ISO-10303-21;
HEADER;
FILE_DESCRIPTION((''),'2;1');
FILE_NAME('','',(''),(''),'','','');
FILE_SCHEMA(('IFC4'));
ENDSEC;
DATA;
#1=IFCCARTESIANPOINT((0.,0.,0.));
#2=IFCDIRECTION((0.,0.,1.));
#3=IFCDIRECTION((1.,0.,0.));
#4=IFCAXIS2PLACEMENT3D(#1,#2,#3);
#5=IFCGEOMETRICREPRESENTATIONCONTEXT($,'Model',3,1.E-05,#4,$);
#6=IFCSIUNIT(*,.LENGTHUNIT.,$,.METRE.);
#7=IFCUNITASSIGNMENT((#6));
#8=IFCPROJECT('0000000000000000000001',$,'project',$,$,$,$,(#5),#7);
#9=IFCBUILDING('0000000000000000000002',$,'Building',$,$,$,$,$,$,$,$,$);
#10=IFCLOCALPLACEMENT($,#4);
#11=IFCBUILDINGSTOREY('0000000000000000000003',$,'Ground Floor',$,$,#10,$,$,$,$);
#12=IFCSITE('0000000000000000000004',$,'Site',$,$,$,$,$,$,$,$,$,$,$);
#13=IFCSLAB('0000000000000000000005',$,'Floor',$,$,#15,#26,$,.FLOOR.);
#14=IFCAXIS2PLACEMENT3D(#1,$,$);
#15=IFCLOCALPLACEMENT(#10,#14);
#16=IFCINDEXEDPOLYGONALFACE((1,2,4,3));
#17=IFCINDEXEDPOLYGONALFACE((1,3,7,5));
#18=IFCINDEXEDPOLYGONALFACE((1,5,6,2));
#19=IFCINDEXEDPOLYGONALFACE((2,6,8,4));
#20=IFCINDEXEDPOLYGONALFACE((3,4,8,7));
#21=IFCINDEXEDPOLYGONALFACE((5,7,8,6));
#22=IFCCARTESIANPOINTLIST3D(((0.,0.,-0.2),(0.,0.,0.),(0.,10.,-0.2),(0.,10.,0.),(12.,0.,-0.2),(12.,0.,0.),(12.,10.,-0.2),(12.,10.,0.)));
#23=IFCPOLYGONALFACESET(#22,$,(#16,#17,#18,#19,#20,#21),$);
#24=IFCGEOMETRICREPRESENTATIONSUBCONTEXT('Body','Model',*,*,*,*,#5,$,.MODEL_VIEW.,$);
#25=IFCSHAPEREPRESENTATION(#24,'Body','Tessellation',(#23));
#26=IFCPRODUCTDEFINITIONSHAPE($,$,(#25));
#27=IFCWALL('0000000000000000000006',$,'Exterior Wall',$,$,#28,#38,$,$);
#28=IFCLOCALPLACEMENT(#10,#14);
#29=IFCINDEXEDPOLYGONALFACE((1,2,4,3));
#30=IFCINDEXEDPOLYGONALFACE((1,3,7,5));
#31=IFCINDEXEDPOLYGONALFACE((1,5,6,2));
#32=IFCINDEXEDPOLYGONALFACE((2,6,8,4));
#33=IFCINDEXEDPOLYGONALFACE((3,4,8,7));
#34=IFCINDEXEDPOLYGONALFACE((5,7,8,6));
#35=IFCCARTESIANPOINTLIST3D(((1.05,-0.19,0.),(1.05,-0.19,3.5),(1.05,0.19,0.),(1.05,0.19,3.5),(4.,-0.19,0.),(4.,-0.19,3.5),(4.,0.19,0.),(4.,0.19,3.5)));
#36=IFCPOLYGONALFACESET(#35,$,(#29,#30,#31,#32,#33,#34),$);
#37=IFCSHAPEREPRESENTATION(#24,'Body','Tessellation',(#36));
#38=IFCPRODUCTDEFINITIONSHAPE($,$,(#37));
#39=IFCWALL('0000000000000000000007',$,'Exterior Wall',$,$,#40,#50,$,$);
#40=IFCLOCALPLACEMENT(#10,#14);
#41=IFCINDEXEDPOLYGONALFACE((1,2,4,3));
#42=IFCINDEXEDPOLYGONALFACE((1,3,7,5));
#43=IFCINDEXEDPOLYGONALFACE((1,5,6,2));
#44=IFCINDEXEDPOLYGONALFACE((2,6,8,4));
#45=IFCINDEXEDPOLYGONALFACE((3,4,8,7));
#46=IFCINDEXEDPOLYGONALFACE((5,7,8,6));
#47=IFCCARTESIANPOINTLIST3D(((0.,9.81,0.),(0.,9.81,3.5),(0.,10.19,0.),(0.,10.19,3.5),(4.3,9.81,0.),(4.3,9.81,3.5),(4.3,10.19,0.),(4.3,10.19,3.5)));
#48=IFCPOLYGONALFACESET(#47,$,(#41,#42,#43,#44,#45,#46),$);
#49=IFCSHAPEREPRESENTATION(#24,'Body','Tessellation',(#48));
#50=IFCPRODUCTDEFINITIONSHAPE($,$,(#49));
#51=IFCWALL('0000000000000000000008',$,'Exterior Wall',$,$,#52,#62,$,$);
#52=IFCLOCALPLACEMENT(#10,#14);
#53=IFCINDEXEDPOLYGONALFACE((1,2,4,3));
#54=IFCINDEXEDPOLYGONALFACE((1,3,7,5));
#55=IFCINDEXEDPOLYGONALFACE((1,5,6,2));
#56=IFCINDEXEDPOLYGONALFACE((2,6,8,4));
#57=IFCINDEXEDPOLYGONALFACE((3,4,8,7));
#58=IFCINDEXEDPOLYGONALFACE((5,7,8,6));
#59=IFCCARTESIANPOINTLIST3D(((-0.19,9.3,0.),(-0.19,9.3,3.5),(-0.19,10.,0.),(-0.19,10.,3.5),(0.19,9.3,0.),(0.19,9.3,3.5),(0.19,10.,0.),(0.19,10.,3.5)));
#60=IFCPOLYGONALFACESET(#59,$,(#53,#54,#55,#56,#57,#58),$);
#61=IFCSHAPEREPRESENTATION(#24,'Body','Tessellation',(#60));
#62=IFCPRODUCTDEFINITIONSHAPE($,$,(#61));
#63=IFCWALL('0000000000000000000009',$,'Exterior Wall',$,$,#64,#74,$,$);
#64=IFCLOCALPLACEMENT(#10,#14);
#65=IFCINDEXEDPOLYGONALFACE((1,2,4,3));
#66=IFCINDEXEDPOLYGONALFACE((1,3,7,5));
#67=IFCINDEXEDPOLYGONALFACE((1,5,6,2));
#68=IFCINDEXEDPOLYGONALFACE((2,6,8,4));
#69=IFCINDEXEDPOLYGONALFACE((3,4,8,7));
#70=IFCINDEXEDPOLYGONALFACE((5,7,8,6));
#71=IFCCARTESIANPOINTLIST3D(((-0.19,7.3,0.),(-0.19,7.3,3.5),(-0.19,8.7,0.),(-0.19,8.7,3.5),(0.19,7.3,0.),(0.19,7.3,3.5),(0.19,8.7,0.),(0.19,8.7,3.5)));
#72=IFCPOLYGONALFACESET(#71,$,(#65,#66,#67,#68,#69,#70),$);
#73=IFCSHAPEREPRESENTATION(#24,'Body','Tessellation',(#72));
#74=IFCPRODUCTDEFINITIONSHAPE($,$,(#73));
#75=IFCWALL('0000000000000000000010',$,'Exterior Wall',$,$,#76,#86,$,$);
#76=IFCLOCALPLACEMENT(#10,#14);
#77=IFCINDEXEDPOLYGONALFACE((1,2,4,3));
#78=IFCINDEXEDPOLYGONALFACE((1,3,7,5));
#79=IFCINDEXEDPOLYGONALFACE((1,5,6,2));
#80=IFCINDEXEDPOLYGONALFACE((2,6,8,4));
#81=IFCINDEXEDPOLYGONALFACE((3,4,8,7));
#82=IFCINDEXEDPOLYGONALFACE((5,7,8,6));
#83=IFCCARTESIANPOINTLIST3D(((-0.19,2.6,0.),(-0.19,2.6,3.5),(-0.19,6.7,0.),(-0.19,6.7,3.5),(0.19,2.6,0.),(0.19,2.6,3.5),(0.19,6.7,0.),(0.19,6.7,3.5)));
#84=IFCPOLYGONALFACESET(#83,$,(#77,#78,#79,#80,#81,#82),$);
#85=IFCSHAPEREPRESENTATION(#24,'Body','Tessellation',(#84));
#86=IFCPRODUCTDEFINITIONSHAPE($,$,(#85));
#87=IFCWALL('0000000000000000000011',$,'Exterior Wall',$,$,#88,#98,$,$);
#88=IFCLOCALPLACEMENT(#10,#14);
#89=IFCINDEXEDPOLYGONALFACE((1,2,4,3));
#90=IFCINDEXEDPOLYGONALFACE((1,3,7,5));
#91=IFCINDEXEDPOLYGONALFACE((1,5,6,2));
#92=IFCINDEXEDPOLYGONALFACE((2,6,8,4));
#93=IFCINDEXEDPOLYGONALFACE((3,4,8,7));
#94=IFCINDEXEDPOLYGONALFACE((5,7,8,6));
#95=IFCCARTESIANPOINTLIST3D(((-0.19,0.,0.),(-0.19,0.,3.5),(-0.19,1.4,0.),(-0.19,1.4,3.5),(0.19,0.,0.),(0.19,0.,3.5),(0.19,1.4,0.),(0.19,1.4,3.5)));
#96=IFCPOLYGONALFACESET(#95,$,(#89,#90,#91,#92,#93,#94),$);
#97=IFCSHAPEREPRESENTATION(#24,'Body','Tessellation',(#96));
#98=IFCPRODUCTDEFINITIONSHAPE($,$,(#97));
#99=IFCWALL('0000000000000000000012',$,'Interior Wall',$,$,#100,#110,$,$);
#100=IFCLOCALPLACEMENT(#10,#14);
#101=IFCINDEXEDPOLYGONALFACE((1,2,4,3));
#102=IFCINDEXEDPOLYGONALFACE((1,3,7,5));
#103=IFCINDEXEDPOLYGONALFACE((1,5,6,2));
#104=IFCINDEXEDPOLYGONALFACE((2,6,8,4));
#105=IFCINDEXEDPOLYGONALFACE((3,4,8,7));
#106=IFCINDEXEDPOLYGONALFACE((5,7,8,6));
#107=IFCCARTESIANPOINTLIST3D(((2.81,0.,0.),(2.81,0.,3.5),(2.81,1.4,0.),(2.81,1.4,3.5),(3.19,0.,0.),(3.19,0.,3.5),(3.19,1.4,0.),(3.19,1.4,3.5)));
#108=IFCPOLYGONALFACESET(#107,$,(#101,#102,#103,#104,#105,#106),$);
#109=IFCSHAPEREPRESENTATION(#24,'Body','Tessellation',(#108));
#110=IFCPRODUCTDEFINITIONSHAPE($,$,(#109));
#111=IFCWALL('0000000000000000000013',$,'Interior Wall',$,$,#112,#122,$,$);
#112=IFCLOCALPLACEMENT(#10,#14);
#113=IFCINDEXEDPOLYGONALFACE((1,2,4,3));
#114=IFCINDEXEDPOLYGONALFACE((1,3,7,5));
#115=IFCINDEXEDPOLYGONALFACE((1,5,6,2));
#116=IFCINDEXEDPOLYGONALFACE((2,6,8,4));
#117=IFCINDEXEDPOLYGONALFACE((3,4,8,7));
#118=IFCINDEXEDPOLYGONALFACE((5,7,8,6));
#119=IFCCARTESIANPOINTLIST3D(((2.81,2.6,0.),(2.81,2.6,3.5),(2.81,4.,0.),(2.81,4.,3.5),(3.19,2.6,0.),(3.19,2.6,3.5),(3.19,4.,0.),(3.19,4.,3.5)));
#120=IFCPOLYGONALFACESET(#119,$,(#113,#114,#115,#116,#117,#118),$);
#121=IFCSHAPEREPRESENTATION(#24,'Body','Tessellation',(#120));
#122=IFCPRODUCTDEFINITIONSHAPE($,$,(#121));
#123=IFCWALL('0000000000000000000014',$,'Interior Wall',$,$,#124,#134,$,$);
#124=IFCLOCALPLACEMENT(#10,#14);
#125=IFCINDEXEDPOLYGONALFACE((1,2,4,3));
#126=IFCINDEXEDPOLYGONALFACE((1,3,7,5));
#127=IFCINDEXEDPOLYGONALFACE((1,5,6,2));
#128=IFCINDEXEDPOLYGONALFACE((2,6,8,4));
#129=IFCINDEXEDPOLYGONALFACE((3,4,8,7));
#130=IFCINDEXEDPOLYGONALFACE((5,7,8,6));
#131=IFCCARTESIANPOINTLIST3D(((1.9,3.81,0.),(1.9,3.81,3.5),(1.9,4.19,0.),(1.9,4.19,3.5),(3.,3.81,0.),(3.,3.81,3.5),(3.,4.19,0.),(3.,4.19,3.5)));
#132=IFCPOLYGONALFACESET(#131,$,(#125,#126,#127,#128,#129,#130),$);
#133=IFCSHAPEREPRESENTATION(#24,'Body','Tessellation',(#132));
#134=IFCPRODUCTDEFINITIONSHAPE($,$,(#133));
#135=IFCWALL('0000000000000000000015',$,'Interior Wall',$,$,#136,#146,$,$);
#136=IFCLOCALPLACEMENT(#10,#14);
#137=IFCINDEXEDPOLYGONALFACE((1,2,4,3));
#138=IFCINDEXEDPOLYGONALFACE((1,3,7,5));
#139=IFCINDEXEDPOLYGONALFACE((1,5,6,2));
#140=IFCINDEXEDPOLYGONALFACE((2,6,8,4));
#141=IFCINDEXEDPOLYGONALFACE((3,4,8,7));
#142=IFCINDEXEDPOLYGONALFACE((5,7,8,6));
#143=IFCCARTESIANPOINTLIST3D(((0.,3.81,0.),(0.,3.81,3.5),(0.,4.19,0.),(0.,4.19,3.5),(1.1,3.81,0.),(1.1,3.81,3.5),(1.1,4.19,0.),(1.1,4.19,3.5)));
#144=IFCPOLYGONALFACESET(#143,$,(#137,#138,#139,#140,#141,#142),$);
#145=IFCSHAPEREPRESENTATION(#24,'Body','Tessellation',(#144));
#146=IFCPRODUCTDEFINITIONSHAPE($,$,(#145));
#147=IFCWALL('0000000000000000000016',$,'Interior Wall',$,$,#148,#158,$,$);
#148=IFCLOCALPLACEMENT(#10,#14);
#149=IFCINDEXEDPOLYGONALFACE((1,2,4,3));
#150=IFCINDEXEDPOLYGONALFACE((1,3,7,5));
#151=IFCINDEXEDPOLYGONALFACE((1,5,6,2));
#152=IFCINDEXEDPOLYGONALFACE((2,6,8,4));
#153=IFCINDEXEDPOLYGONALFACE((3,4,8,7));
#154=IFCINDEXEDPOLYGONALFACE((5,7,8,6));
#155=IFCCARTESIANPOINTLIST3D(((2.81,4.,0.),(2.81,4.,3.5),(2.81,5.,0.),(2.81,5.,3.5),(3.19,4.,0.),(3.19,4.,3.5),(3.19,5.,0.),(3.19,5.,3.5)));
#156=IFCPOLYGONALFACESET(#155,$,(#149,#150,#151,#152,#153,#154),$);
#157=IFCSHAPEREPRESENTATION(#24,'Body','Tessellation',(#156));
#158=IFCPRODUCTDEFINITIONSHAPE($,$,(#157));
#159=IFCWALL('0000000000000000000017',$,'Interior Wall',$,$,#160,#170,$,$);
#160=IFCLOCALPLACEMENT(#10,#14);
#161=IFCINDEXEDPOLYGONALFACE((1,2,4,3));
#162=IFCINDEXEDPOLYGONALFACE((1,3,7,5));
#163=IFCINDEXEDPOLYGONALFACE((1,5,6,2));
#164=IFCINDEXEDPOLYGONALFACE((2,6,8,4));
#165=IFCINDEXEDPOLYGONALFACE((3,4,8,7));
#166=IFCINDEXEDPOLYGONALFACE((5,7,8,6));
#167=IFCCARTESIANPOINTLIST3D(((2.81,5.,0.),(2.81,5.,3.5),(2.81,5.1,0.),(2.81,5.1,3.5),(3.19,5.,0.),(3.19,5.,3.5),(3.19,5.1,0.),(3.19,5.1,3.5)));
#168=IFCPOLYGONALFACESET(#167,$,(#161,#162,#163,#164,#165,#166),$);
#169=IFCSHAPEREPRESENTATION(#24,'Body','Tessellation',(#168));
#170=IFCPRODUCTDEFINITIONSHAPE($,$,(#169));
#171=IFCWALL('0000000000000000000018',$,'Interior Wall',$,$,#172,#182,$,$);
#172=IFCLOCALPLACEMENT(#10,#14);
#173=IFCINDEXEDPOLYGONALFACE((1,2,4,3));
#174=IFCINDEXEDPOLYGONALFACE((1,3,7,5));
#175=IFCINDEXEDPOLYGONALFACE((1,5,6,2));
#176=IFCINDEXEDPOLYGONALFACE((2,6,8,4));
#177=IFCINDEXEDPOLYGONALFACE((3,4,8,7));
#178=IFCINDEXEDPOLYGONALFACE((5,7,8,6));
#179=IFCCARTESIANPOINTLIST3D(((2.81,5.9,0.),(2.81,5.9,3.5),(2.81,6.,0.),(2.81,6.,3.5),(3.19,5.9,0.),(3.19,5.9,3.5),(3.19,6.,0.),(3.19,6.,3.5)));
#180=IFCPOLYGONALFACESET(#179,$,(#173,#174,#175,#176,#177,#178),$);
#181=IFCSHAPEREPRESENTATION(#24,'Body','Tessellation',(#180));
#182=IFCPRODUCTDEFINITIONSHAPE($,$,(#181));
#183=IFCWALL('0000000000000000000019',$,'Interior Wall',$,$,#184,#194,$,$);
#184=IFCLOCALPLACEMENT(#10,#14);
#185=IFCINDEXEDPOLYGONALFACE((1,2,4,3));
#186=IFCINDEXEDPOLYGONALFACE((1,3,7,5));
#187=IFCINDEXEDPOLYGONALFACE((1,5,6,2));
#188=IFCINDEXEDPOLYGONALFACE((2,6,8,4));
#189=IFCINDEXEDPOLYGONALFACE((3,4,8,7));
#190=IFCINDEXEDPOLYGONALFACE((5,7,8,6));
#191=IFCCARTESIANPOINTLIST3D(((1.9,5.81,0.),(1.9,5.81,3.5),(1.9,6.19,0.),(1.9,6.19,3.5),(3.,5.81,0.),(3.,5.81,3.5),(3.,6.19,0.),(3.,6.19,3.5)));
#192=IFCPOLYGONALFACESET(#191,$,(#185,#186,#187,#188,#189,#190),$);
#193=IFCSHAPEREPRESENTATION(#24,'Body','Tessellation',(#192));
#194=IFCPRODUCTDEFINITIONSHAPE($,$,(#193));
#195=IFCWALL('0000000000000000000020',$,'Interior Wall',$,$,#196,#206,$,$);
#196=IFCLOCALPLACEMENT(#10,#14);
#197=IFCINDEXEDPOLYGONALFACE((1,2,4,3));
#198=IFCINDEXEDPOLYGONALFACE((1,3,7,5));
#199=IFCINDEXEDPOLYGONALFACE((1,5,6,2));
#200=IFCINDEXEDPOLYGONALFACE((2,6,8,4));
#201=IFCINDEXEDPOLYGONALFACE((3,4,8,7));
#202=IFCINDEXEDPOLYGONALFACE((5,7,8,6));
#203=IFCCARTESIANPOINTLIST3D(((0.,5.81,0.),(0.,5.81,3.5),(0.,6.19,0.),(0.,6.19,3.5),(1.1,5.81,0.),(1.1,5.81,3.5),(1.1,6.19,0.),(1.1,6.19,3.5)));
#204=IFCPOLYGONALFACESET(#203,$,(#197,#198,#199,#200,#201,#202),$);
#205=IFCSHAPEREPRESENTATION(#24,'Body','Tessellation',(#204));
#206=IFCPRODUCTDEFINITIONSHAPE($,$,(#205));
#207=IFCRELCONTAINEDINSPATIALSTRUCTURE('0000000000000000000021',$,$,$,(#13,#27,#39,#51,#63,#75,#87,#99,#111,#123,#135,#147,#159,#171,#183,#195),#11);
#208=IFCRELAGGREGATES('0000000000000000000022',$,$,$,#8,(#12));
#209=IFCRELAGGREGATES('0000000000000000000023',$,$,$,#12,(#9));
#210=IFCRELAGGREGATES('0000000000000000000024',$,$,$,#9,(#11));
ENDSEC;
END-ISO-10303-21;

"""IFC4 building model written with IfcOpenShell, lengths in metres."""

from ifc_helpers import new_model, si_unit, frame, origin_with_axes, place, context, subcontext, project, spatial, indexed_curve, outline, extrude, element, save


model = new_model("IFC4")

# Units and contexts
model_context = context("Model", 3, precision=1e-05, world=origin_with_axes())
body_context = subcontext(model_context, "Body", "Model", "MODEL_VIEW")
ifc_project = project(units=[si_unit("LENGTHUNIT", "METRE")], contexts=[model_context])

# Site, building, storey
site = spatial("IfcSite", under=ifc_project, Name="Site")
building = spatial("IfcBuilding", under=site, Name="Building")
storey_placement = place(None, origin_with_axes())
storey = spatial("IfcBuildingStorey", under=building, at=storey_placement, Name="Ground Floor")

# Slab
slab_placement = place(storey_placement, frame((0.0, 0.0, -0.2), z_axis=(0.0, 0.0, 1.0), x_axis=(1.0, 0.0, 0.0)))
element("IfcSlab", 1, at=slab_placement, inside=storey, Name="Floor", PredefinedType="FLOOR", context=body_context, shape_type="SweptSolid", body=[
    extrude(outline(indexed_curve([(0.0, 0.0), (12.0, 0.0), (12.0, 10.0), (0.0, 10.0)])), None, (0.0, 0.0, 1.0), 0.2),
])

# Walls
wall_1_placement = place(storey_placement, frame((1.05, 0.0, 0.0), z_axis=(0.0, 0.0, 1.0), x_axis=(1.0, 0.0, 0.0)))
element("IfcWall", 2, at=wall_1_placement, inside=storey, Name="Exterior Wall", context=body_context, shape_type="SweptSolid", body=[
    extrude(outline(indexed_curve([(0.0, 0.0), (0.0, 0.38), (2.95, 0.38), (2.95, 0.0), (0.0, 0.0)], self_intersect=False)), frame((0.0, -0.19, 0.0), z_axis=(0.0, 0.0, 1.0), x_axis=(1.0, 0.0, 0.0)), (0.0, 0.0, 1.0), 3.5),
])
wall_2_placement = place(storey_placement, frame((4.3, 10.0, 0.0), z_axis=(0.0, 0.0, 1.0), x_axis=(-1.0, 0.0, 0.0)))
element("IfcWall", 3, at=wall_2_placement, inside=storey, Name="Exterior Wall", context=body_context, shape_type="SweptSolid", body=[
    extrude(outline(indexed_curve([(0.0, 0.0), (0.0, 0.38), (4.3, 0.38), (4.3, 0.0), (0.0, 0.0)], self_intersect=False)), frame((0.0, -0.19, 0.0), z_axis=(0.0, 0.0, 1.0), x_axis=(1.0, 0.0, 0.0)), (0.0, 0.0, 1.0), 3.5),
])
wall_3_placement = place(storey_placement, frame((0.0, 10.0, 0.0), z_axis=(0.0, 0.0, 1.0), x_axis=(0.0, -1.0, 0.0)))
element("IfcWall", 4, at=wall_3_placement, inside=storey, Name="Exterior Wall", context=body_context, shape_type="SweptSolid", body=[
    extrude(outline(indexed_curve([(0.0, 0.0), (0.0, 0.38), (0.7, 0.38), (0.7, 0.0), (0.0, 0.0)], self_intersect=False)), frame((0.0, -0.19, 0.0), z_axis=(0.0, 0.0, 1.0), x_axis=(1.0, 0.0, 0.0)), (0.0, 0.0, 1.0), 3.5),
])
wall_4_placement = place(storey_placement, frame((0.0, 8.7, 0.0), z_axis=(0.0, 0.0, 1.0), x_axis=(0.0, -1.0, 0.0)))
element("IfcWall", 5, at=wall_4_placement, inside=storey, Name="Exterior Wall", context=body_context, shape_type="SweptSolid", body=[
    extrude(outline(indexed_curve([(0.0, 0.0), (0.0, 0.38), (1.4, 0.38), (1.4, 0.0), (0.0, 0.0)], self_intersect=False)), frame((0.0, -0.19, 0.0), z_axis=(0.0, 0.0, 1.0), x_axis=(1.0, 0.0, 0.0)), (0.0, 0.0, 1.0), 3.5),
])
wall_5_placement = place(storey_placement, frame((0.0, 6.7, 0.0), z_axis=(0.0, 0.0, 1.0), x_axis=(0.0, -1.0, 0.0)))
element("IfcWall", 6, at=wall_5_placement, inside=storey, Name="Exterior Wall", context=body_context, shape_type="SweptSolid", body=[
    extrude(outline(indexed_curve([(0.0, 0.0), (0.0, 0.38), (4.1, 0.38), (4.1, 0.0), (0.0, 0.0)], self_intersect=False)), frame((0.0, -0.19, 0.0), z_axis=(0.0, 0.0, 1.0), x_axis=(1.0, 0.0, 0.0)), (0.0, 0.0, 1.0), 3.5),
])
wall_6_placement = place(storey_placement, frame((0.0, 1.4, 0.0), z_axis=(0.0, 0.0, 1.0), x_axis=(0.0, -1.0, 0.0)))
element("IfcWall", 7, at=wall_6_placement, inside=storey, Name="Exterior Wall", context=body_context, shape_type="SweptSolid", body=[
    extrude(outline(indexed_curve([(0.0, 0.0), (0.0, 0.38), (1.4, 0.38), (1.4, 0.0), (0.0, 0.0)], self_intersect=False)), frame((0.0, -0.19, 0.0), z_axis=(0.0, 0.0, 1.0), x_axis=(1.0, 0.0, 0.0)), (0.0, 0.0, 1.0), 3.5),
])
for number, where, z_axis, x_axis, name in (
    (8, (3.0, 0.0, 0.0), (0.0, 0.0, 1.0), (0.0, 1.0, 0.0), "Interior Wall"),
    (9, (3.0, 2.6, 0.0), (0.0, 0.0, 1.0), (0.0, 1.0, 0.0), "Interior Wall"),
):
    element("IfcWall", number, at=place(storey_placement, frame(where, z_axis=z_axis, x_axis=x_axis)), inside=storey, Name=name, context=body_context, shape_type="SweptSolid", body=[
        extrude(outline(indexed_curve([(0.0, 0.0), (0.0, 0.38), (1.4, 0.38), (1.4, 0.0), (0.0, 0.0)], self_intersect=False)), frame((0.0, -0.19, 0.0), z_axis=(0.0, 0.0, 1.0), x_axis=(1.0, 0.0, 0.0)), (0.0, 0.0, 1.0), 3.5),
    ])
for number, where, z_axis, x_axis, name in (
    (10, (3.0, 4.0, 0.0), (0.0, 0.0, 1.0), (-1.0, 0.0, 0.0), "Interior Wall"),
    (11, (1.1, 4.0, 0.0), (0.0, 0.0, 1.0), (-1.0, 0.0, 0.0), "Interior Wall"),
):
    element("IfcWall", number, at=place(storey_placement, frame(where, z_axis=z_axis, x_axis=x_axis)), inside=storey, Name=name, context=body_context, shape_type="SweptSolid", body=[
        extrude(outline(indexed_curve([(0.0, 0.0), (0.0, 0.38), (1.1, 0.38), (1.1, 0.0), (0.0, 0.0)], self_intersect=False)), frame((0.0, -0.19, 0.0), z_axis=(0.0, 0.0, 1.0), x_axis=(1.0, 0.0, 0.0)), (0.0, 0.0, 1.0), 3.5),
    ])
wall_7_placement = place(storey_placement, frame((3.0, 5.0, 0.0), z_axis=(0.0, 0.0, 1.0), x_axis=(0.0, -1.0, 0.0)))
element("IfcWall", 12, at=wall_7_placement, inside=storey, Name="Interior Wall", context=body_context, shape_type="SweptSolid", body=[
    extrude(outline(indexed_curve([(0.0, 0.0), (0.0, 0.38), (1.0, 0.38), (1.0, 0.0), (0.0, 0.0)], self_intersect=False)), frame((0.0, -0.19, 0.0), z_axis=(0.0, 0.0, 1.0), x_axis=(1.0, 0.0, 0.0)), (0.0, 0.0, 1.0), 3.5),
])
for number, where, z_axis, x_axis, name in (
    (13, (3.0, 5.0, 0.0), (0.0, 0.0, 1.0), (0.0, 1.0, 0.0), "Interior Wall"),
    (14, (3.0, 5.9, 0.0), (0.0, 0.0, 1.0), (0.0, 1.0, 0.0), "Interior Wall"),
):
    element("IfcWall", number, at=place(storey_placement, frame(where, z_axis=z_axis, x_axis=x_axis)), inside=storey, Name=name, context=body_context, shape_type="SweptSolid", body=[
        extrude(outline(indexed_curve([(0.0, 0.0), (0.0, 0.38), (0.1, 0.38), (0.1, 0.0), (0.0, 0.0)], self_intersect=False)), frame((0.0, -0.19, 0.0), z_axis=(0.0, 0.0, 1.0), x_axis=(1.0, 0.0, 0.0)), (0.0, 0.0, 1.0), 3.5),
    ])
for number, where, z_axis, x_axis, name in (
    (15, (3.0, 6.0, 0.0), (0.0, 0.0, 1.0), (-1.0, 0.0, 0.0), "Interior Wall"),
    (16, (1.1, 6.0, 0.0), (0.0, 0.0, 1.0), (-1.0, 0.0, 0.0), "Interior Wall"),
):
    element("IfcWall", number, at=place(storey_placement, frame(where, z_axis=z_axis, x_axis=x_axis)), inside=storey, Name=name, context=body_context, shape_type="SweptSolid", body=[
        extrude(outline(indexed_curve([(0.0, 0.0), (0.0, 0.38), (1.1, 0.38), (1.1, 0.0), (0.0, 0.0)], self_intersect=False)), frame((0.0, -0.19, 0.0), z_axis=(0.0, 0.0, 1.0), x_axis=(1.0, 0.0, 0.0)), (0.0, 0.0, 1.0), 3.5),
    ])

save(model, "model.ifc")
